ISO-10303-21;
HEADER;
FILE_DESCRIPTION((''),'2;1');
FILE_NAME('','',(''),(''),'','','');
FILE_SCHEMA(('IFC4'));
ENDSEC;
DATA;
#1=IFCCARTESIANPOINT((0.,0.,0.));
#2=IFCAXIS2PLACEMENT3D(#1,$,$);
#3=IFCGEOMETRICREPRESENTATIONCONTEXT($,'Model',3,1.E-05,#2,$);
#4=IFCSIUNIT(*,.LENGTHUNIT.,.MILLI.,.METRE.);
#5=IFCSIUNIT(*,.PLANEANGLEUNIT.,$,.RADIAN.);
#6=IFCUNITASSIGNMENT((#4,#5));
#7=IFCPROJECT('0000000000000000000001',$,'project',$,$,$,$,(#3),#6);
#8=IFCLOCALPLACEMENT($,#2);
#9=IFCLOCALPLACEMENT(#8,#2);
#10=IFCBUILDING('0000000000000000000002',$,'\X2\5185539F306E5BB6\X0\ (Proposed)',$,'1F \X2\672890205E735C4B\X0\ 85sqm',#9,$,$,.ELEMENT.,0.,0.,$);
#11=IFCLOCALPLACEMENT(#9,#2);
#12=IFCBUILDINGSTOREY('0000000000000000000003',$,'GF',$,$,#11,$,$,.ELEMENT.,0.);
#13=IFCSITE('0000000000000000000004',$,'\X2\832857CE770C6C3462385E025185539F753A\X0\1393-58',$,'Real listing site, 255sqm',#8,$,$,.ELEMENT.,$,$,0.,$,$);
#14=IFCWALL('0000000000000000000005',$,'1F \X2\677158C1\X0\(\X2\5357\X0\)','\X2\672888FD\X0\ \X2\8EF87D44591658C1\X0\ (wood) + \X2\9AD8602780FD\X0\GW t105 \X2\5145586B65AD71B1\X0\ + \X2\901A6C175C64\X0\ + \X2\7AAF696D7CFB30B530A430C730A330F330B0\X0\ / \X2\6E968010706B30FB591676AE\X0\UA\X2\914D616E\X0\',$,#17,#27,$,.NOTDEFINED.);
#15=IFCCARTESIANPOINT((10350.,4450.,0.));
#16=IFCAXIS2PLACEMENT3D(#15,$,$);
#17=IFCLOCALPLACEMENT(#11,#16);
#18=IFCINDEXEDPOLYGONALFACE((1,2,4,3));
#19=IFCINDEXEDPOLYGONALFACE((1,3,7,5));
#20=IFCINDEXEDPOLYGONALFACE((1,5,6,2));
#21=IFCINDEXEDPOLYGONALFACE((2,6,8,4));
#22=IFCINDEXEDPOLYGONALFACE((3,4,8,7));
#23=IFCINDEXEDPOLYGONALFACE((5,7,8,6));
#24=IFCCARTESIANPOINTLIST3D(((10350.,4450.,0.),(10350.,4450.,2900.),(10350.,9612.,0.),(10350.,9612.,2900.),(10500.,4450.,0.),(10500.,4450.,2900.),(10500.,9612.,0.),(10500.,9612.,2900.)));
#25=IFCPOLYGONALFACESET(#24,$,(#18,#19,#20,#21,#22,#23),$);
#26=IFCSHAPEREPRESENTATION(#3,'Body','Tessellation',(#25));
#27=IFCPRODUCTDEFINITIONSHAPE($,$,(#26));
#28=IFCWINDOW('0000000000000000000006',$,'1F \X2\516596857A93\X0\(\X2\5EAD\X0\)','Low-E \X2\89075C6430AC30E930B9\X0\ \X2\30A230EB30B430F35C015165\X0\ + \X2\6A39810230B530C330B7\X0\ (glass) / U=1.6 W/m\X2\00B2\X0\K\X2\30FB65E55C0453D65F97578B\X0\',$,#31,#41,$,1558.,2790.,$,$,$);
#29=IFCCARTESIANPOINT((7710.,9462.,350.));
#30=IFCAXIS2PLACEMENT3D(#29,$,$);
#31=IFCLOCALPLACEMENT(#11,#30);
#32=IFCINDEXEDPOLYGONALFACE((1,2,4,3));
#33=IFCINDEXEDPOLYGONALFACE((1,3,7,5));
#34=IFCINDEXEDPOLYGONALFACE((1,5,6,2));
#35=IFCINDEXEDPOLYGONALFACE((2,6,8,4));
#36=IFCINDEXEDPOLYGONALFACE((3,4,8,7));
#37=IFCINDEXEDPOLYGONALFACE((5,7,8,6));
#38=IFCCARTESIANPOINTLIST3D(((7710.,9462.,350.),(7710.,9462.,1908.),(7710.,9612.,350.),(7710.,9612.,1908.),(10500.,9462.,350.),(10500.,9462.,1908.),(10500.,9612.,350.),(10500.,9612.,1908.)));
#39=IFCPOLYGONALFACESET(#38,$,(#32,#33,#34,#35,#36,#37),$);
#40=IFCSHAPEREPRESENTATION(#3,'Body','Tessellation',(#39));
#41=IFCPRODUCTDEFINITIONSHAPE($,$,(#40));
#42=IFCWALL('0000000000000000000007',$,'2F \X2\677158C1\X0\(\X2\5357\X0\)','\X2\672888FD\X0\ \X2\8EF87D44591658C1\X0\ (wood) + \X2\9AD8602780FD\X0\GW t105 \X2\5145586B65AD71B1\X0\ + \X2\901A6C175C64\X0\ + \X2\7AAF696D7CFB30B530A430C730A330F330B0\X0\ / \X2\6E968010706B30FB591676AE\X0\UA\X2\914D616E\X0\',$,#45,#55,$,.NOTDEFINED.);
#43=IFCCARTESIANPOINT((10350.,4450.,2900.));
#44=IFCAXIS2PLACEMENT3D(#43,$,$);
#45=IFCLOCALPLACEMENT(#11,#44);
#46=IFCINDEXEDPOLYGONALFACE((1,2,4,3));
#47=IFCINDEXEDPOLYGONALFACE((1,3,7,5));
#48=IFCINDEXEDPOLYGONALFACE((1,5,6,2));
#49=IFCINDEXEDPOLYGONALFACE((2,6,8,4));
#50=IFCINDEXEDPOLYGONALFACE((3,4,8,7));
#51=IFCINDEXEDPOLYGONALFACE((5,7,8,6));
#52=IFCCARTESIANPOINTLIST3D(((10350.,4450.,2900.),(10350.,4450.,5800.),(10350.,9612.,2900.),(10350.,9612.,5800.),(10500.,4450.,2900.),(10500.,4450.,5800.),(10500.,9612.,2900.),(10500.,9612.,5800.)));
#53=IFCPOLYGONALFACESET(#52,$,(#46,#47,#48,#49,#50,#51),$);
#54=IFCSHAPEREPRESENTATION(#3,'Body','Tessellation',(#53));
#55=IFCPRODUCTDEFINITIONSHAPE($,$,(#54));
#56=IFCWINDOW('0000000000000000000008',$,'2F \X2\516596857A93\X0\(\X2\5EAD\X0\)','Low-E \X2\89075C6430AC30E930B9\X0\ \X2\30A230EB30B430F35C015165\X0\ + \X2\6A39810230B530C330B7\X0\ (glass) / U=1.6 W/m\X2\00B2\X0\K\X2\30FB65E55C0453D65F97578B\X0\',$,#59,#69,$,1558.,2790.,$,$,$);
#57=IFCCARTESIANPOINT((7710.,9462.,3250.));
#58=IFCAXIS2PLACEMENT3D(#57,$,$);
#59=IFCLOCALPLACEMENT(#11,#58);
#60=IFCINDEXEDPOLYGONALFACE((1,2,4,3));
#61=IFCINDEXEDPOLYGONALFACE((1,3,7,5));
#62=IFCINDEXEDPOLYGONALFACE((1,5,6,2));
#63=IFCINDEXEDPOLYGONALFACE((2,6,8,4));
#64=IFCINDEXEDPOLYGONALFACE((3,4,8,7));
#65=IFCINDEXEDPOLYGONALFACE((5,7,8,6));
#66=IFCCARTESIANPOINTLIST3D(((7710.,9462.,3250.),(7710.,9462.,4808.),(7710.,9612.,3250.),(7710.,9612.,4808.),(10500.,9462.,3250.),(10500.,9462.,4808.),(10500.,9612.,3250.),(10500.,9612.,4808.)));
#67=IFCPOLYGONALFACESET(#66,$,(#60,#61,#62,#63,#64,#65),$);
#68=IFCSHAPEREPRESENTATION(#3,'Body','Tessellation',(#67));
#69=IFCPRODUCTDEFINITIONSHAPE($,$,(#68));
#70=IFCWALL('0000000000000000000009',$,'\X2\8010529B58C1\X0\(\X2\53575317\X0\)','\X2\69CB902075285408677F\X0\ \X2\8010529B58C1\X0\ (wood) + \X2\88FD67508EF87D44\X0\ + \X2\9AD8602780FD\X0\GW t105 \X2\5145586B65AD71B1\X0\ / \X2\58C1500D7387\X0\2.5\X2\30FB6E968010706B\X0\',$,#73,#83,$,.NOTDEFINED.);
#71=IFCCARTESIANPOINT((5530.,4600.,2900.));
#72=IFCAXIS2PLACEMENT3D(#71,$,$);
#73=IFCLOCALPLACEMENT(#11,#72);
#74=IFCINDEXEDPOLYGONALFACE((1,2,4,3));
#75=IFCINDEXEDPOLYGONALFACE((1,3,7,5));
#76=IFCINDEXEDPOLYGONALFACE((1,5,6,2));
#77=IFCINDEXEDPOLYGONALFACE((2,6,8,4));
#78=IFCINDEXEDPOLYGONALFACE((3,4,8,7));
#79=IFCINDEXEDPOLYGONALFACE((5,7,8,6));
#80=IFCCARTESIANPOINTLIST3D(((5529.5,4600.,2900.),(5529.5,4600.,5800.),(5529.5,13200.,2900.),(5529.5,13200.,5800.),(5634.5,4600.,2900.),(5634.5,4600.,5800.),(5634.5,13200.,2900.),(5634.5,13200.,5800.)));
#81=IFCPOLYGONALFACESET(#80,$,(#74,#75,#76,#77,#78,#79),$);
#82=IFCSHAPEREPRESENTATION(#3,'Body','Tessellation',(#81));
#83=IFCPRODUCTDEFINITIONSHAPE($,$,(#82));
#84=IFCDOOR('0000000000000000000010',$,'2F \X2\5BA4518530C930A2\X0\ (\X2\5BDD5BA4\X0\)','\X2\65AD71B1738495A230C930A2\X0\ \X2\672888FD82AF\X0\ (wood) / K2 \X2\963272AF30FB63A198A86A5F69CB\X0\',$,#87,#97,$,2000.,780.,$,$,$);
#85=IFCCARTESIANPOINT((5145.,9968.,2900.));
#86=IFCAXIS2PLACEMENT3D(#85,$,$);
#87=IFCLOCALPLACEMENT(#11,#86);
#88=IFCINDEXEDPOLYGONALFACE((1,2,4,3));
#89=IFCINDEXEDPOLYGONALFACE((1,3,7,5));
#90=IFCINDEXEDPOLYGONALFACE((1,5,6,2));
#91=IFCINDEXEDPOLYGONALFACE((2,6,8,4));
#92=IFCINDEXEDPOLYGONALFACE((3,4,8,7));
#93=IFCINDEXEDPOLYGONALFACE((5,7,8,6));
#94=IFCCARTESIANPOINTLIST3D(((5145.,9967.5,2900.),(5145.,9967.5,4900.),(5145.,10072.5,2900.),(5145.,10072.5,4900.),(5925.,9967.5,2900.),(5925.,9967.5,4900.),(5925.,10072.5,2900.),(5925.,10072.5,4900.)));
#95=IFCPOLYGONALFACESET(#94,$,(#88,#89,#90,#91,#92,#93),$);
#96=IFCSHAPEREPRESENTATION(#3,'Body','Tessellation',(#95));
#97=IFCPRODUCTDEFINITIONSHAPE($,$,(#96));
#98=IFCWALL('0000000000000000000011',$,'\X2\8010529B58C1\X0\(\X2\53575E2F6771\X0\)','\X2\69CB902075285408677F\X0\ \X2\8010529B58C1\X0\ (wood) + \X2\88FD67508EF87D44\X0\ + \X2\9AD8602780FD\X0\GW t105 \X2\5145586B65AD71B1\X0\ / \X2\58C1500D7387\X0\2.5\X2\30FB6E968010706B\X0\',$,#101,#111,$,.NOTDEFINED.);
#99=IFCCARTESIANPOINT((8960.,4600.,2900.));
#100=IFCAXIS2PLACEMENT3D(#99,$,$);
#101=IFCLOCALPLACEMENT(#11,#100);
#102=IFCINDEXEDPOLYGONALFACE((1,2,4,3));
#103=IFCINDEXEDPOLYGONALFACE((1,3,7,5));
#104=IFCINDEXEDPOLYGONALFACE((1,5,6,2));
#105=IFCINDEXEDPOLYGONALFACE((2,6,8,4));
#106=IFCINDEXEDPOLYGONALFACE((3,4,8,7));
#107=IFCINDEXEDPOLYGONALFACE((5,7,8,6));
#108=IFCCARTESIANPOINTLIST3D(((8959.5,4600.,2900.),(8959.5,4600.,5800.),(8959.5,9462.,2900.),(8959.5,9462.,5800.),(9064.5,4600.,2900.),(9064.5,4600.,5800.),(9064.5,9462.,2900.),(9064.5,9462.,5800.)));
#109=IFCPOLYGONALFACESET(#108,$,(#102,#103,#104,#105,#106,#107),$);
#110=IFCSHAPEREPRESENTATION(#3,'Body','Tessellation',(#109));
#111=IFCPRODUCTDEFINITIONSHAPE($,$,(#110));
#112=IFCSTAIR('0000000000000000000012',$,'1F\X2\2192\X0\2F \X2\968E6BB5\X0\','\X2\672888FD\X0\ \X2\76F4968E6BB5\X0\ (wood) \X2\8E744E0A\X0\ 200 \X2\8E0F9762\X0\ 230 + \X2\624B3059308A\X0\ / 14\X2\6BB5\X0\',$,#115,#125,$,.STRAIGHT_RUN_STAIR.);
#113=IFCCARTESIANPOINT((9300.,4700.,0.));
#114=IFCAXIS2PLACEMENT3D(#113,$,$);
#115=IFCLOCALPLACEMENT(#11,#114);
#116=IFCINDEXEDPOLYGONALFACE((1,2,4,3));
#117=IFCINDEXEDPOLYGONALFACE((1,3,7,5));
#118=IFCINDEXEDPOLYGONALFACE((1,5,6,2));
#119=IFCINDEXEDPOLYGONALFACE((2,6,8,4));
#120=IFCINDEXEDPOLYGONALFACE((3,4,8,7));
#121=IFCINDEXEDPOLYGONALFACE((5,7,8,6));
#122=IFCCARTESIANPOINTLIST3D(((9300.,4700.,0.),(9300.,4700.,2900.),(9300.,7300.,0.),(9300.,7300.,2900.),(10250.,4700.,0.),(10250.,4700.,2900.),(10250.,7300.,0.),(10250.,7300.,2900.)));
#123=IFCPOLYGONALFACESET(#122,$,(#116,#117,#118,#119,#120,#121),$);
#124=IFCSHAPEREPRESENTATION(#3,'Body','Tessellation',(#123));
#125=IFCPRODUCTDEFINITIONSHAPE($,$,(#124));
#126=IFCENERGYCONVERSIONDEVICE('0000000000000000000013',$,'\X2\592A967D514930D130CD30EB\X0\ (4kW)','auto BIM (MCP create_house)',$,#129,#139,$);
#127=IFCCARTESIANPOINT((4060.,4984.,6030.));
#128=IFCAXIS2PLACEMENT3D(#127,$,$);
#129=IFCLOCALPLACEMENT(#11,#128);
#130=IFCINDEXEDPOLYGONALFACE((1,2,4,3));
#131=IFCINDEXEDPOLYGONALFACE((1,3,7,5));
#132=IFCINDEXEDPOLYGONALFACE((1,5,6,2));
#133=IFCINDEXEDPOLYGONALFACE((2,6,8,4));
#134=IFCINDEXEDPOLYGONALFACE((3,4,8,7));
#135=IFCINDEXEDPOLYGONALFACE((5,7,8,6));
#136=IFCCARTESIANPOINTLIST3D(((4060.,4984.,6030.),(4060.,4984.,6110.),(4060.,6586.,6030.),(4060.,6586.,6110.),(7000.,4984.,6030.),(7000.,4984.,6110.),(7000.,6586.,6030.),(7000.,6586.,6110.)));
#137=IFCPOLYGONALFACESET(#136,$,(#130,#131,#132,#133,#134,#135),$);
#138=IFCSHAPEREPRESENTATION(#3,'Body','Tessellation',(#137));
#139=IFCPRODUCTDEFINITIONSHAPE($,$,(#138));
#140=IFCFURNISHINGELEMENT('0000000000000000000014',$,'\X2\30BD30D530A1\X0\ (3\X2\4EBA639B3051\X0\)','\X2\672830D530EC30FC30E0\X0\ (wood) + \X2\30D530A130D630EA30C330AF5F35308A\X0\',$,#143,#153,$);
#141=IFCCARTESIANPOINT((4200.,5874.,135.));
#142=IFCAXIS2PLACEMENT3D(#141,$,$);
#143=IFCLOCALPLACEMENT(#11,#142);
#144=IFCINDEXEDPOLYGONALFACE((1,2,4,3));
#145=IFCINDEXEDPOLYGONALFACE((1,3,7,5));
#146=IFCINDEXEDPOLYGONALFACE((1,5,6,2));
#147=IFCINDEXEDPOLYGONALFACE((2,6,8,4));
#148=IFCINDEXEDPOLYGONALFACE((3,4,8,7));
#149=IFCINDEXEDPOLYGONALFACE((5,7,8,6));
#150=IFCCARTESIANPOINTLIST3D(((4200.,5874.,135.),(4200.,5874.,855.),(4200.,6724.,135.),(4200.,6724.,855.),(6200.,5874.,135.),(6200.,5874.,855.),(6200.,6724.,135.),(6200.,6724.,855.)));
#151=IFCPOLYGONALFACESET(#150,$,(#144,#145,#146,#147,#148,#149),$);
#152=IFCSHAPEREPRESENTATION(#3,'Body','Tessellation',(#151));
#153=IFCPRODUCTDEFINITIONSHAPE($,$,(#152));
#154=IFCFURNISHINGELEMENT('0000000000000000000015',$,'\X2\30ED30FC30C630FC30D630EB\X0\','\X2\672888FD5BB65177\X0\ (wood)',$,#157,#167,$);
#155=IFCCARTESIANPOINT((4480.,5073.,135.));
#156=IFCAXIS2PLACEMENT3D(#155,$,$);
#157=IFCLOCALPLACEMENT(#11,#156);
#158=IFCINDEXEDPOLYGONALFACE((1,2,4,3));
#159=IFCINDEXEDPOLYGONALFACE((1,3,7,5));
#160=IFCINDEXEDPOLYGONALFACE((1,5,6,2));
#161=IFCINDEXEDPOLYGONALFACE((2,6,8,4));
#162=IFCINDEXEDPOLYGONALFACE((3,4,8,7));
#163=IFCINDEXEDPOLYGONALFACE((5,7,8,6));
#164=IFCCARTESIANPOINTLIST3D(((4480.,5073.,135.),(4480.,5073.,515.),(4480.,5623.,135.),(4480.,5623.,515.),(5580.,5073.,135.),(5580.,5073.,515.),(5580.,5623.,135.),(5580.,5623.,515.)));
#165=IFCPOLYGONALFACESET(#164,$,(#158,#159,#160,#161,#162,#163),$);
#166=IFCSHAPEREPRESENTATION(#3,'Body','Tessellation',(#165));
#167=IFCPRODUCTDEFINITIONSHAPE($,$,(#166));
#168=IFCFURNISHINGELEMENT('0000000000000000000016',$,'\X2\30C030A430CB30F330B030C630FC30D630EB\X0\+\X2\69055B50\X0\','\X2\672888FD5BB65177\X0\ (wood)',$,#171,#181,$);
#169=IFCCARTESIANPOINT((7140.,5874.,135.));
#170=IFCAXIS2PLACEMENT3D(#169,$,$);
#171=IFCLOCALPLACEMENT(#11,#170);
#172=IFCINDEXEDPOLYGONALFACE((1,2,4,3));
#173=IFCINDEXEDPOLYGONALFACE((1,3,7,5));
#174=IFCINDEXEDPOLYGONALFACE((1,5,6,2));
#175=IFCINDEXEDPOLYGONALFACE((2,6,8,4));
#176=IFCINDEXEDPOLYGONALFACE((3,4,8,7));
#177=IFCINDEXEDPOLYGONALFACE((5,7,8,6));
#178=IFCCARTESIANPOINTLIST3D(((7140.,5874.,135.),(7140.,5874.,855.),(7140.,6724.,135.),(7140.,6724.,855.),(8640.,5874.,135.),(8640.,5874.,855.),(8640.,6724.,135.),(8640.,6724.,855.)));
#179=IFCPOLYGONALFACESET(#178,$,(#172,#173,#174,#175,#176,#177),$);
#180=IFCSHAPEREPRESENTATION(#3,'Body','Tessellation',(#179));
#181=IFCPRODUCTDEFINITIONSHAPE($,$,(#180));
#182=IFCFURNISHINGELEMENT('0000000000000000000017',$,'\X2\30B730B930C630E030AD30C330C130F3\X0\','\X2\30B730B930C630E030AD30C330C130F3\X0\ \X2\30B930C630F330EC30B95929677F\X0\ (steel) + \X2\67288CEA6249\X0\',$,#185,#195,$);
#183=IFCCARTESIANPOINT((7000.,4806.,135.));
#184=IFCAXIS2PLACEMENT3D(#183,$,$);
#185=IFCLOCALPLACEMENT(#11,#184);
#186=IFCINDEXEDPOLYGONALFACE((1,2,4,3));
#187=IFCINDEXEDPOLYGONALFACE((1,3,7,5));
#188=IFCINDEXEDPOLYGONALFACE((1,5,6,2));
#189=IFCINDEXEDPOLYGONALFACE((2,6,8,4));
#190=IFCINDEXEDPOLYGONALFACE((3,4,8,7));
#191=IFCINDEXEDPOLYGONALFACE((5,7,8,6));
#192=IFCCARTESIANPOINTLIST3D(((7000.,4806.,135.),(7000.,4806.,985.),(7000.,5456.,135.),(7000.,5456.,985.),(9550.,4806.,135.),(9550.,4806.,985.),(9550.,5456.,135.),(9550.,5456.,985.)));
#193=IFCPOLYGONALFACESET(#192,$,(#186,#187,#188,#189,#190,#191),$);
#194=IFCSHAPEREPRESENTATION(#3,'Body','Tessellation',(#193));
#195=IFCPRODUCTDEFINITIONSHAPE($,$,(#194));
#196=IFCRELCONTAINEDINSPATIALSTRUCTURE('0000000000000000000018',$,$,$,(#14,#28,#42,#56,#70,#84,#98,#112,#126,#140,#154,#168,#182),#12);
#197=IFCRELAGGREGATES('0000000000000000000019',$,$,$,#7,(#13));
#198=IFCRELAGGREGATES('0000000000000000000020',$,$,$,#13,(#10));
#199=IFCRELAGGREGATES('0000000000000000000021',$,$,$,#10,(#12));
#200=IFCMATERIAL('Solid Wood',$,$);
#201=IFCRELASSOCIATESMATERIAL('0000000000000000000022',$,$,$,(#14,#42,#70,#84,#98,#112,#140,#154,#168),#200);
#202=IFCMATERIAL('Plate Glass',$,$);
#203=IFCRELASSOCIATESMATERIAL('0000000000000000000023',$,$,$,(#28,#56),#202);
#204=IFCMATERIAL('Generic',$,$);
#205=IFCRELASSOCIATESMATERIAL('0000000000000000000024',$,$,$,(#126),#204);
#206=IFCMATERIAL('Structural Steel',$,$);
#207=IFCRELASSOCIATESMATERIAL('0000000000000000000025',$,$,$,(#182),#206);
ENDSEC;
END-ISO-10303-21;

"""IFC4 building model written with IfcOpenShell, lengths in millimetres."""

from ifc_helpers import new_model, si_unit, frame, frame_2d, origin, place, context, project, spatial, rectangle, extrude, material, element, fill, save


model = new_model("IFC4")

# Units and contexts
model_context = context("Model", 3, precision=1e-05, world=origin())
ifc_project = project(units=[si_unit("LENGTHUNIT", "METRE", prefix="MILLI"), si_unit("PLANEANGLEUNIT", "RADIAN")], contexts=[model_context])

# Site, building, storey
site_placement = place(None, origin())
site = spatial("IfcSite", under=ifc_project, at=site_placement, Name="茨城県水戸市内原町1393-58", ObjectType="Real listing site, 255sqm", CompositionType="ELEMENT", RefElevation=0.0)
building_placement = place(site_placement, origin())
building = spatial("IfcBuilding", under=site, at=building_placement, Name="内原の家 (Proposed)", ObjectType="1F 木造平屋 85sqm", CompositionType="ELEMENT", ElevationOfRefHeight=0.0, ElevationOfTerrain=0.0)
storey_placement = place(building_placement, origin())
storey = spatial("IfcBuildingStorey", under=building, at=storey_placement, Name="GF", CompositionType="ELEMENT", Elevation=0.0)

# Wall, opening, window
ifc_material_1 = material(Name="Solid Wood")
wall_1_placement = place(storey_placement, frame((10350.0, 4450.0, 0.0)))
wall_1 = element("IfcWall", 1, at=wall_1_placement, inside=storey, material=ifc_material_1, Name="1F 東壁(南)", Description="木製 軸組外壁 (wood) + 高性能GW t105 充填断熱 + 通気層 + 窯業系サイディング / 準耐火・外皮UA配慮", PredefinedType="NOTDEFINED", context=model_context, shape_type="SweptSolid", body=[
    extrude(rectangle(XDim=150.0, YDim=5162.0, at=frame_2d((75.0, 2581.0))), frame((10350.0, 4450.0, 0.0)), (0.0, 0.0, 1.0), 2900.0),
])
opening_1_placement = place(storey_placement, frame((7710.0, 9462.0, 350.0)))
opening_1 = element("IfcOpeningElement", 2, at=opening_1_placement, cuts=wall_1, PredefinedType="NOTDEFINED", context=model_context, shape_type="SweptSolid", body=[
    extrude(rectangle(XDim=2790.0, YDim=150.0, at=frame_2d((1395.0, 75.0))), frame((7710.0, 9462.0, 350.0)), (0.0, 0.0, 1.0), 1558.0),
])
ifc_material_2 = material(Name="Plate Glass")
window_1_placement = place(storey_placement, frame((7710.0, 9462.0, 350.0)))
window_1 = element("IfcWindow", 3, at=window_1_placement, inside=storey, material=ifc_material_2, Name="1F 入隅窓(庭)", Description="Low-E 複層ガラス アルゴン封入 + 樹脂サッシ (glass) / U=1.6 W/m²K・日射取得型", OverallHeight=1558.0, OverallWidth=2790.0, context=model_context, shape_type="SweptSolid", body=[
    extrude(rectangle(XDim=2790.0, YDim=150.0, at=frame_2d((1395.0, 75.0))), frame((7710.0, 9462.0, 350.0)), (0.0, 0.0, 1.0), 1558.0),
])
fill(opening_1, window_1)

# Wall, opening, window
wall_2_placement = place(storey_placement, frame((10350.0, 4450.0, 2900.0)))
wall_2 = element("IfcWall", 4, at=wall_2_placement, inside=storey, material=ifc_material_1, Name="2F 東壁(南)", Description="木製 軸組外壁 (wood) + 高性能GW t105 充填断熱 + 通気層 + 窯業系サイディング / 準耐火・外皮UA配慮", PredefinedType="NOTDEFINED", context=model_context, shape_type="SweptSolid", body=[
    extrude(rectangle(XDim=150.0, YDim=5162.0, at=frame_2d((75.0, 2581.0))), frame((10350.0, 4450.0, 2900.0)), (0.0, 0.0, 1.0), 2900.0),
])
opening_2_placement = place(storey_placement, frame((7710.0, 9462.0, 3250.0)))
opening_2 = element("IfcOpeningElement", 5, at=opening_2_placement, cuts=wall_2, PredefinedType="NOTDEFINED", context=model_context, shape_type="SweptSolid", body=[
    extrude(rectangle(XDim=2790.0, YDim=150.0, at=frame_2d((1395.0, 75.0))), frame((7710.0, 9462.0, 3250.0)), (0.0, 0.0, 1.0), 1558.0),
])
window_2_placement = place(storey_placement, frame((7710.0, 9462.0, 3250.0)))
window_2 = element("IfcWindow", 6, at=window_2_placement, inside=storey, material=ifc_material_2, Name="2F 入隅窓(庭)", Description="Low-E 複層ガラス アルゴン封入 + 樹脂サッシ (glass) / U=1.6 W/m²K・日射取得型", OverallHeight=1558.0, OverallWidth=2790.0, context=model_context, shape_type="SweptSolid", body=[
    extrude(rectangle(XDim=2790.0, YDim=150.0, at=frame_2d((1395.0, 75.0))), frame((7710.0, 9462.0, 3250.0)), (0.0, 0.0, 1.0), 1558.0),
])
fill(opening_2, window_2)

# Wall, opening, door
wall_3_placement = place(storey_placement, frame((5530.0, 4600.0, 2900.0)))
wall_3 = element("IfcWall", 7, at=wall_3_placement, inside=storey, material=ifc_material_1, Name="耐力壁(南北)", Description="構造用合板 耐力壁 (wood) + 製材軸組 + 高性能GW t105 充填断熱 / 壁倍率2.5・準耐火", PredefinedType="NOTDEFINED", context=model_context, shape_type="SweptSolid", body=[
    extrude(rectangle(XDim=105.0, YDim=8600.0, at=frame_2d((52.0, 4300.0))), frame((5530.0, 4600.0, 2900.0)), (0.0, 0.0, 1.0), 2900.0),
])
opening_3_placement = place(storey_placement, frame((5145.0, 9968.0, 2900.0)))
opening_3 = element("IfcOpeningElement", 8, at=opening_3_placement, cuts=wall_3, PredefinedType="NOTDEFINED", context=model_context, shape_type="SweptSolid", body=[
    extrude(rectangle(XDim=780.0, YDim=105.0, at=frame_2d((390.0, 52.0))), frame((5145.0, 9968.0, 2900.0)), (0.0, 0.0, 1.0), 2000.0),
])
door_1_placement = place(storey_placement, frame((5145.0, 9968.0, 2900.0)))
door_1 = element("IfcDoor", 9, at=door_1_placement, inside=storey, material=ifc_material_1, Name="2F 室内ドア (寝室)", Description="断熱玄関ドア 木製芯 (wood) / K2 防犯・採風機構", OverallHeight=2000.0, OverallWidth=780.0, context=model_context, shape_type="SweptSolid", body=[
    extrude(rectangle(XDim=780.0, YDim=105.0, at=frame_2d((390.0, 52.0))), frame((5145.0, 9968.0, 2900.0)), (0.0, 0.0, 1.0), 2000.0),
])
fill(opening_3, door_1)

# Wall
wall_4_placement = place(storey_placement, frame((8960.0, 4600.0, 2900.0)))
element("IfcWall", 10, at=wall_4_placement, inside=storey, material=ifc_material_1, Name="耐力壁(南帯東)", Description="構造用合板 耐力壁 (wood) + 製材軸組 + 高性能GW t105 充填断熱 / 壁倍率2.5・準耐火", PredefinedType="NOTDEFINED", context=model_context, shape_type="SweptSolid", body=[
    extrude(rectangle(XDim=105.0, YDim=4862.0, at=frame_2d((52.0, 2431.0))), frame((8960.0, 4600.0, 2900.0)), (0.0, 0.0, 1.0), 2900.0),
])

# Stair
stair_placement = place(storey_placement, frame((9300.0, 4700.0, 0.0)))
element("IfcStair", 11, at=stair_placement, inside=storey, material=ifc_material_1, Name="1F→2F 階段", Description="木製 直階段 (wood) 蹴上 200 踏面 230 + 手すり / 14段", PredefinedType="STRAIGHT_RUN_STAIR", context=model_context, shape_type="SweptSolid", body=[
    extrude(rectangle(XDim=950.0, YDim=2600.0, at=frame_2d((475.0, 1300.0))), frame((9300.0, 4700.0, 0.0)), (0.0, 0.0, 1.0), 2900.0),
])

# Energy conversion device
ifc_material_3 = material(Name="Generic")
energy_conversion_device_placement = place(storey_placement, frame((4060.0, 4984.0, 6030.0)))
element("IfcEnergyConversionDevice", 12, at=energy_conversion_device_placement, inside=storey, material=ifc_material_3, Name="太陽光パネル (4kW)", Description="auto BIM (MCP create_house)", context=model_context, shape_type="SweptSolid", body=[
    extrude(rectangle(XDim=2940.0, YDim=1602.0, at=frame_2d((1470.0, 801.0))), frame((4060.0, 4984.0, 6030.0)), (0.0, 0.0, 1.0), 80.0),
])

# Furnishing elements
furnishing_1_placement = place(storey_placement, frame((4200.0, 5874.0, 135.0)))
element("IfcFurnishingElement", 13, at=furnishing_1_placement, inside=storey, material=ifc_material_1, Name="ソファ (3人掛け)", Description="木フレーム (wood) + ファブリック張り", context=model_context, shape_type="SweptSolid", body=[
    extrude(rectangle(XDim=2000.0, YDim=850.0, at=frame_2d((1000.0, 425.0))), frame((4200.0, 5874.0, 135.0)), (0.0, 0.0, 1.0), 720.0),
])
furnishing_2_placement = place(storey_placement, frame((4480.0, 5073.0, 135.0)))
element("IfcFurnishingElement", 14, at=furnishing_2_placement, inside=storey, material=ifc_material_1, Name="ローテーブル", Description="木製家具 (wood)", context=model_context, shape_type="SweptSolid", body=[
    extrude(rectangle(XDim=1100.0, YDim=550.0, at=frame_2d((550.0, 275.0))), frame((4480.0, 5073.0, 135.0)), (0.0, 0.0, 1.0), 380.0),
])
furnishing_3_placement = place(storey_placement, frame((7140.0, 5874.0, 135.0)))
element("IfcFurnishingElement", 15, at=furnishing_3_placement, inside=storey, material=ifc_material_1, Name="ダイニングテーブル+椅子", Description="木製家具 (wood)", context=model_context, shape_type="SweptSolid", body=[
    extrude(rectangle(XDim=1500.0, YDim=850.0, at=frame_2d((750.0, 425.0))), frame((7140.0, 5874.0, 135.0)), (0.0, 0.0, 1.0), 720.0),
])
ifc_material_4 = material(Name="Structural Steel")
furnishing_4_placement = place(storey_placement, frame((7000.0, 4806.0, 135.0)))
element("IfcFurnishingElement", 16, at=furnishing_4_placement, inside=storey, material=ifc_material_4, Name="システムキッチン", Description="システムキッチン ステンレス天板 (steel) + 木質扉", context=model_context, shape_type="SweptSolid", body=[
    extrude(rectangle(XDim=2550.0, YDim=650.0, at=frame_2d((1275.0, 325.0))), frame((7000.0, 4806.0, 135.0)), (0.0, 0.0, 1.0), 850.0),
])

save(model, "model.ifc")
